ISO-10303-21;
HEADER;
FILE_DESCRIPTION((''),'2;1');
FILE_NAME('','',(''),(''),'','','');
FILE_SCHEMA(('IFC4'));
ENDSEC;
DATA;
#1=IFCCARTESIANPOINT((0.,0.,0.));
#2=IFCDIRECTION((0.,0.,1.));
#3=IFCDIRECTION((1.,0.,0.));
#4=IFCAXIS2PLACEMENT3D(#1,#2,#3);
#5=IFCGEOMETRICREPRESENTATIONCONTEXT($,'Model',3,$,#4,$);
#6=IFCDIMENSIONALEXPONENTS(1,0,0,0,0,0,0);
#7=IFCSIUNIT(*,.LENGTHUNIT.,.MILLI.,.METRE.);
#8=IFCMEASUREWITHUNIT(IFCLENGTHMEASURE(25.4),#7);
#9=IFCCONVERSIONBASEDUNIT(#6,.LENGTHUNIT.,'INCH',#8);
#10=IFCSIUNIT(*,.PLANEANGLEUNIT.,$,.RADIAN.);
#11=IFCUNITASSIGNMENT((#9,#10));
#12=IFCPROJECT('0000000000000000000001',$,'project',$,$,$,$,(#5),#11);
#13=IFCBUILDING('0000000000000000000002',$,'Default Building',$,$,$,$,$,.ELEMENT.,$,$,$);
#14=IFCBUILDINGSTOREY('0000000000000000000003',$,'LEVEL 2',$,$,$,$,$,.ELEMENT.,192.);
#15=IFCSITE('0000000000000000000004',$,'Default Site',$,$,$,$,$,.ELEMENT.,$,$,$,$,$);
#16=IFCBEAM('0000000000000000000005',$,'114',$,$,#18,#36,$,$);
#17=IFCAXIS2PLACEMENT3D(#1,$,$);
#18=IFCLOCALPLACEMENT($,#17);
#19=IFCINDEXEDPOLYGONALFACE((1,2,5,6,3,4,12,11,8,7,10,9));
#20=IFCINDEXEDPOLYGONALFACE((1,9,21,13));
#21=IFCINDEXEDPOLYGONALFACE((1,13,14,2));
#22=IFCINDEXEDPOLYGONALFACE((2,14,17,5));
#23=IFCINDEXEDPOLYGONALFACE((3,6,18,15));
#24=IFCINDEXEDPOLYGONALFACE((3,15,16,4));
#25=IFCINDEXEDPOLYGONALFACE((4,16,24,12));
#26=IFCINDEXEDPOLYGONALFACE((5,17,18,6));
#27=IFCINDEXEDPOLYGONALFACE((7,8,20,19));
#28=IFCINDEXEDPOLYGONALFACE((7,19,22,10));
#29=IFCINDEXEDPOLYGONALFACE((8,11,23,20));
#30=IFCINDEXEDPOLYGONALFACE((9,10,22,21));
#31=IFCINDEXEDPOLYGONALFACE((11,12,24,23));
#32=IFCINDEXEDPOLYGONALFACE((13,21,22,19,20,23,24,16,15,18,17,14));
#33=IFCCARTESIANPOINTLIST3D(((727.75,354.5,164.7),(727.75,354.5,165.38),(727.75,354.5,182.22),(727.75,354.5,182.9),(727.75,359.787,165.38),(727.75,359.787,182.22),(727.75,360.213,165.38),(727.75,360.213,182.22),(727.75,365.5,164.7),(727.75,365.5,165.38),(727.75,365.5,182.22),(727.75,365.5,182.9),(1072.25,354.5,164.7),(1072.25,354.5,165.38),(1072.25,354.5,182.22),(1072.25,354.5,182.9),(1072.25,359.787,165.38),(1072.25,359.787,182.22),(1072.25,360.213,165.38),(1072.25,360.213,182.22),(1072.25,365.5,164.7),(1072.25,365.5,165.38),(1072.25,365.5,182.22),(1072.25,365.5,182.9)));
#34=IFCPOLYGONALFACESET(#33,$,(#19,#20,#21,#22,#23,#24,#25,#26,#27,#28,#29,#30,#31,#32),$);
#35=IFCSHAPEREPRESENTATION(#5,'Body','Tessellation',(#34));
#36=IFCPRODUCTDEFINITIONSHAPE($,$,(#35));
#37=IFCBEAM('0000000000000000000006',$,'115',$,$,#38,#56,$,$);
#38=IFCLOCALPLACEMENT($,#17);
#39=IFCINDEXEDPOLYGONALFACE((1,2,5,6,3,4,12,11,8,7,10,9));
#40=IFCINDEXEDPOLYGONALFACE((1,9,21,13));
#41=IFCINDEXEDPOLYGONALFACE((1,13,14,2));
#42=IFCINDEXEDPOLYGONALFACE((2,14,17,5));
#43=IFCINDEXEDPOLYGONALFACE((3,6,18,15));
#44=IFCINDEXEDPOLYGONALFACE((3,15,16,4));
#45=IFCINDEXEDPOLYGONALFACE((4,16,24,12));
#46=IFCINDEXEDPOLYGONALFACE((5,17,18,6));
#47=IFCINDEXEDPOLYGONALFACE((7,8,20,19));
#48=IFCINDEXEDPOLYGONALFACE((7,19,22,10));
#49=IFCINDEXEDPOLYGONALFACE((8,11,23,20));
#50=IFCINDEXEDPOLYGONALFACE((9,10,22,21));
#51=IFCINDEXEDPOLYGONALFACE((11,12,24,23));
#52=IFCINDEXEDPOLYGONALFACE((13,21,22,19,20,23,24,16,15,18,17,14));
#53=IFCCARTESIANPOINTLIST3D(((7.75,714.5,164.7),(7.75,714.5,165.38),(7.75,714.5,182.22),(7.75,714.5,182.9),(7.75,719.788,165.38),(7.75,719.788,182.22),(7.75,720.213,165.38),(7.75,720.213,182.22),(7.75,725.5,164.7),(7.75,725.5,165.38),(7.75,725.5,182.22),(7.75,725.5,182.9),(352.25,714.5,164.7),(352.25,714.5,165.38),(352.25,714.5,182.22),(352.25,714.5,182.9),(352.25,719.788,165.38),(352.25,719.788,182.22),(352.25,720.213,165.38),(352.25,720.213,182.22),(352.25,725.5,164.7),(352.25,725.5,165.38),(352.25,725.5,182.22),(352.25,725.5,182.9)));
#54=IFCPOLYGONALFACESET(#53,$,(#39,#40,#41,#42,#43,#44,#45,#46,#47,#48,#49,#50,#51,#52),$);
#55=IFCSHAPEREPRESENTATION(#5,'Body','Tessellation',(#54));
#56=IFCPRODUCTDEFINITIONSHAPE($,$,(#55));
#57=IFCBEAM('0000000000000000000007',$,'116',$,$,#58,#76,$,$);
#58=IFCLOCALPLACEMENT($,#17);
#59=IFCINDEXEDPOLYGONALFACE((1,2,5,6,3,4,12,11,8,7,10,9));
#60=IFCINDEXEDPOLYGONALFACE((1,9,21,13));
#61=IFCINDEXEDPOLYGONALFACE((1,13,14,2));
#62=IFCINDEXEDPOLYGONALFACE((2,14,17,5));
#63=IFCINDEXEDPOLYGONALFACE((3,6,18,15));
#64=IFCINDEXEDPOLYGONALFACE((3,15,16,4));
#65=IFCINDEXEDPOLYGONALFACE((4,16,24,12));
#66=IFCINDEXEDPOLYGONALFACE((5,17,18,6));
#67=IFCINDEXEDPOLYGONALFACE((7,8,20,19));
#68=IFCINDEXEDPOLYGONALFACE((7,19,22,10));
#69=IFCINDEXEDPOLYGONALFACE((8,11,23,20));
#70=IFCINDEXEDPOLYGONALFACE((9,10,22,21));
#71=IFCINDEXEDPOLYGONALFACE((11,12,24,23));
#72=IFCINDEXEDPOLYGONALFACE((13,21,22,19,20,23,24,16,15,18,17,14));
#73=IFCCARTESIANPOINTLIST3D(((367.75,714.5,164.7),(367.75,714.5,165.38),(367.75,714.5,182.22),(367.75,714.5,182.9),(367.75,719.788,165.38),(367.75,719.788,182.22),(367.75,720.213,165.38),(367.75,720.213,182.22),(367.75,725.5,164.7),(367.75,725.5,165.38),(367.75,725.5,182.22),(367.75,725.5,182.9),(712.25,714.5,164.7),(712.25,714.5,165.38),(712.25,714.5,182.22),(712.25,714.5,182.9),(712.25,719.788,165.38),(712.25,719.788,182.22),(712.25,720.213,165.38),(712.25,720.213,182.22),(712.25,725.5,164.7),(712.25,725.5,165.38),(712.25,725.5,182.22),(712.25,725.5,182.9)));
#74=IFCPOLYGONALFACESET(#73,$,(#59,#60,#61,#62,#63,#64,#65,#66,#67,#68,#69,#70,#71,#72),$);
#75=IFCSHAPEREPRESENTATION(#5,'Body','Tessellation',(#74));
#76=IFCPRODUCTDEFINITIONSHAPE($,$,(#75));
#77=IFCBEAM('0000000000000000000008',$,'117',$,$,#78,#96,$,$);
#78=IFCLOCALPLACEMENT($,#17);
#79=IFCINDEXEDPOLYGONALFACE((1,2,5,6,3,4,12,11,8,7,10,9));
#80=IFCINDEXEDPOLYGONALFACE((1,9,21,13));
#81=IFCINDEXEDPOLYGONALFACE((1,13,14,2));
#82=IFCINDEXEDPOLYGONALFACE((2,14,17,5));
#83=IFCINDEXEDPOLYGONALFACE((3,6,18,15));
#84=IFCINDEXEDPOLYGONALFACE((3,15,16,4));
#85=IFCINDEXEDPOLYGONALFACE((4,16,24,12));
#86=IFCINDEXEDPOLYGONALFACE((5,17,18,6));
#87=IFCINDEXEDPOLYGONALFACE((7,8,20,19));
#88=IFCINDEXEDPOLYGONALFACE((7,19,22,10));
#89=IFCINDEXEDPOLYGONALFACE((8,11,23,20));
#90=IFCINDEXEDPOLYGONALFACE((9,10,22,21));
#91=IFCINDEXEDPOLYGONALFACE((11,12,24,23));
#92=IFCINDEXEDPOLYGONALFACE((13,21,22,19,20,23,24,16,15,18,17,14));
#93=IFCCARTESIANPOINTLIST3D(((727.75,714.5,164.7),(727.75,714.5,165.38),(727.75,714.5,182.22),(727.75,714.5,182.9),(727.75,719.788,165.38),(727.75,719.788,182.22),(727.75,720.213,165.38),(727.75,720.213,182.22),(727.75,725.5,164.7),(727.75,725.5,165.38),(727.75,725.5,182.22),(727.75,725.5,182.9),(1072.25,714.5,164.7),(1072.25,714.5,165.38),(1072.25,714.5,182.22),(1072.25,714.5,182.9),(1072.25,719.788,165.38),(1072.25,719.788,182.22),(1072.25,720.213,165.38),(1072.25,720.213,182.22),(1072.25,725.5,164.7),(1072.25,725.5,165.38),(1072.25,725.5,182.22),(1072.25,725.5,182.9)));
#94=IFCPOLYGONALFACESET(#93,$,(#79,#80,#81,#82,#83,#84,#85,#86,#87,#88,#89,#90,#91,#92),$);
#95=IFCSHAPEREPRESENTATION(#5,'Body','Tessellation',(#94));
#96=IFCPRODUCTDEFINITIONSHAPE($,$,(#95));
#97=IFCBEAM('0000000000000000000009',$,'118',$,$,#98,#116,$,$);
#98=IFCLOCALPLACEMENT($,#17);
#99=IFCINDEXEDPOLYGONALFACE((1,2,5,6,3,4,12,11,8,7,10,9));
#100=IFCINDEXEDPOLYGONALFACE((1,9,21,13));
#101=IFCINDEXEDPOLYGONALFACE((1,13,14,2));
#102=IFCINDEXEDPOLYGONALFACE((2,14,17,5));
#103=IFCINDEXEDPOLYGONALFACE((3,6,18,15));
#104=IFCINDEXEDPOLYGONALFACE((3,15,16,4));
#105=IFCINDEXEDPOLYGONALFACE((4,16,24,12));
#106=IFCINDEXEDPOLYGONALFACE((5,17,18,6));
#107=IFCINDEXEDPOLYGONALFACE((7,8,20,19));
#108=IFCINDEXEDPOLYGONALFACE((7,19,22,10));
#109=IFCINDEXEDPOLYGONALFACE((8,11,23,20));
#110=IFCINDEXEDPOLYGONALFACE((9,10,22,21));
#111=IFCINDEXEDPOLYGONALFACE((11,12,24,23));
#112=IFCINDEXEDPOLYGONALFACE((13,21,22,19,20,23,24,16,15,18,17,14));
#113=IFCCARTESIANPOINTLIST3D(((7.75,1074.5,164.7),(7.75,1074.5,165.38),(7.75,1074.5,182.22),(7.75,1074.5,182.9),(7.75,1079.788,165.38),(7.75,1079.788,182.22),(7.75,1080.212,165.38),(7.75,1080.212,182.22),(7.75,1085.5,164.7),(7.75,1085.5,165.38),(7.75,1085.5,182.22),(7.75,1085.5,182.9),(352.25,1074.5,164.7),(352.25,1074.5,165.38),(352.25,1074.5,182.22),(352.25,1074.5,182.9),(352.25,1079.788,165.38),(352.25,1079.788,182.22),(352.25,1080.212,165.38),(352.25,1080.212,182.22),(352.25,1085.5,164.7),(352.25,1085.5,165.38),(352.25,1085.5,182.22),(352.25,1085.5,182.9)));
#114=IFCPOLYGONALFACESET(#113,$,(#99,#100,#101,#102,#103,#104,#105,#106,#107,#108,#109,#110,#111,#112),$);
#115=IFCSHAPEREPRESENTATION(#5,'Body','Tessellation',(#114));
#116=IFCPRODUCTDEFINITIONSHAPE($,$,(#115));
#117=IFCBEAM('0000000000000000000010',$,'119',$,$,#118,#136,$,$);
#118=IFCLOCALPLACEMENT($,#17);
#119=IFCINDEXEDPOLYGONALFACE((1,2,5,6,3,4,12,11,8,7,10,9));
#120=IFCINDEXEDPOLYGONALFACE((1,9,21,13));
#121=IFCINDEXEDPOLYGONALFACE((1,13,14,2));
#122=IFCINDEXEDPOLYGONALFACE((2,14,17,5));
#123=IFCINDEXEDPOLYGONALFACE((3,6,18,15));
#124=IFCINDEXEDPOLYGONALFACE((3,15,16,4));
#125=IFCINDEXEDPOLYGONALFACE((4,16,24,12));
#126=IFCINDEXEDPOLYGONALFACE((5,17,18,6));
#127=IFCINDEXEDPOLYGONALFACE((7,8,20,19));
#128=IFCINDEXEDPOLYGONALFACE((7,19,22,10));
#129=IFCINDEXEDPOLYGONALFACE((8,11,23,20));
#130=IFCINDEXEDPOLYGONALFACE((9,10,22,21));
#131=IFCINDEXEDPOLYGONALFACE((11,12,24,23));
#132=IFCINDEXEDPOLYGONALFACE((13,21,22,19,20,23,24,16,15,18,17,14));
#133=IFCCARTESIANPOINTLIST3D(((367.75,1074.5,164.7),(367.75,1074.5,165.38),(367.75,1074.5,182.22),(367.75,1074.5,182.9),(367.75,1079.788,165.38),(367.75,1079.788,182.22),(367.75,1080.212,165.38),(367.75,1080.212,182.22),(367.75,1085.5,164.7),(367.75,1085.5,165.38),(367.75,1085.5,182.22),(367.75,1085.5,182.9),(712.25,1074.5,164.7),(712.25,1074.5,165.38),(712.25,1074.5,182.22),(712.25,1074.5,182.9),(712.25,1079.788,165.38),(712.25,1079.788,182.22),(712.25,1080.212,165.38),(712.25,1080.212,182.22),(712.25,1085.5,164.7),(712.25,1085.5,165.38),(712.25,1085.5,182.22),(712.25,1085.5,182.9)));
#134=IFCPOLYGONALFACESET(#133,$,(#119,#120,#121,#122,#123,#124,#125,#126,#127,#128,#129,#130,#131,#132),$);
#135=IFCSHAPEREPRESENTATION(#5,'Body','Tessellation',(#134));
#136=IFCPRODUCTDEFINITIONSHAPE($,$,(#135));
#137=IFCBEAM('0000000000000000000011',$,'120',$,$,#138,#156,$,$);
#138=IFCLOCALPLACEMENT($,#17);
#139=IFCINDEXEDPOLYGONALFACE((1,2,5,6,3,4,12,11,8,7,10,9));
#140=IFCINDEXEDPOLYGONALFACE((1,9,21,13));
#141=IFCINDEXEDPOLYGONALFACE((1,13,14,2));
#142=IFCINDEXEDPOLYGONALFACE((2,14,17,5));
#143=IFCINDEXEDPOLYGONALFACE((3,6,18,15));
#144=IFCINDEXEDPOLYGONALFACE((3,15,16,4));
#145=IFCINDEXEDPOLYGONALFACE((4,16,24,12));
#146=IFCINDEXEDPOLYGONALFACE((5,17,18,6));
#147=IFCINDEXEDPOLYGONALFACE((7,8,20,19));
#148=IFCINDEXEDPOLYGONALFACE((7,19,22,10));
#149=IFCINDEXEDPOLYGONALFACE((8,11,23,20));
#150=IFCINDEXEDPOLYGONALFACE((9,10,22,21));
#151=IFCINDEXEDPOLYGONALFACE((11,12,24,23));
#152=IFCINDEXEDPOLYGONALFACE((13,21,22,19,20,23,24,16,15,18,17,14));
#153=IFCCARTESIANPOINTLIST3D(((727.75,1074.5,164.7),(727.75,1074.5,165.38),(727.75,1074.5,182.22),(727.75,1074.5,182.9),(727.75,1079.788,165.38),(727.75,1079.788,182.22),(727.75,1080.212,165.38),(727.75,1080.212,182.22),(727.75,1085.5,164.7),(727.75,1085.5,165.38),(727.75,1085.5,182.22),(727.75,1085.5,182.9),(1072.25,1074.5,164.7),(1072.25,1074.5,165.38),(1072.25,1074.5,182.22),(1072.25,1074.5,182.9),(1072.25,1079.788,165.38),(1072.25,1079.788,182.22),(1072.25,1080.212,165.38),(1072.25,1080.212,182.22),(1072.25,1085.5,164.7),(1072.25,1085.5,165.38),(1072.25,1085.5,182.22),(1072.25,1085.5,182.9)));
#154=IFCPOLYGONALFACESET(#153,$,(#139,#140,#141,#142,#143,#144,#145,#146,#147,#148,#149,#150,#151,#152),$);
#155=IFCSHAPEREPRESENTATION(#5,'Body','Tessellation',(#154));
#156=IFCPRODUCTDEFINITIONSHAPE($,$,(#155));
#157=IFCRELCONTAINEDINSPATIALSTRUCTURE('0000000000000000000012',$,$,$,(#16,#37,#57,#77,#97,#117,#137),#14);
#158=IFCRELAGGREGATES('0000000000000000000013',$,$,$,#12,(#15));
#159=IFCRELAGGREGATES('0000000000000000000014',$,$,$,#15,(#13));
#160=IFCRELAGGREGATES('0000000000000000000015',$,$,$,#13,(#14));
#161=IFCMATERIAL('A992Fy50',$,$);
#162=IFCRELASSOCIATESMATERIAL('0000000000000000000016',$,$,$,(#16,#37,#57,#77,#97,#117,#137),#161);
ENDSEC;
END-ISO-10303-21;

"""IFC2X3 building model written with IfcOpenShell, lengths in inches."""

from ifc_helpers import new_model, entity, si_unit, converted_unit, frame, origin_with_axes, origin_2d_with_axis, place, context, project, spatial, i_section, transform_2d, derived_profile, extrude, material, element, save


model = new_model("IFC2X3")

# Units and contexts
model_context = context("Model", 3, world=origin_with_axes())
ifc_project = project(units=[converted_unit("LENGTHUNIT", "INCH", entity("IfcLengthMeasure", 25.4), si_unit("LENGTHUNIT", "METRE", prefix="MILLI"), dimensions=[1, 0, 0, 0, 0, 0, 0]), si_unit("PLANEANGLEUNIT", "RADIAN")], contexts=[model_context])

# Site, building, storey
site = spatial("IfcSite", under=ifc_project, Name="Default Site", CompositionType="ELEMENT")
building = spatial("IfcBuilding", under=site, Name="Default Building", CompositionType="ELEMENT")
storey = spatial("IfcBuildingStorey", under=building, Name="LEVEL 2", CompositionType="ELEMENT", Elevation=192.0)

# Shared definitions
ifc_material = material(Name="A992Fy50")

# Beams
for number, where, z_axis, x_axis, name in (
    (1, (727.75, 360.0, 192.0), (1.0, 0.0, 0.0), (0.0, 1.0, 0.0), "114"),
    (2, (7.75, 720.0, 192.0), (1.0, 0.0, 0.0), (0.0, 1.0, 0.0), "115"),
    (3, (367.75, 720.0, 192.0), (1.0, 0.0, 0.0), (0.0, 1.0, 0.0), "116"),
    (4, (727.75, 720.0, 192.0), (1.0, 0.0, 0.0), (0.0, 1.0, 0.0), "117"),
    (5, (7.75, 1080.0, 192.0), (1.0, 0.0, 0.0), (0.0, 1.0, 0.0), "118"),
    (6, (367.75, 1080.0, 192.0), (1.0, 0.0, 0.0), (0.0, 1.0, 0.0), "119"),
    (7, (727.75, 1080.0, 192.0), (1.0, 0.0, 0.0), (0.0, 1.0, 0.0), "120"),
):
    element("IfcBeam", number, at=place(None, frame(where, z_axis=z_axis, x_axis=x_axis)), inside=storey, material=ifc_material, Name=name, context=model_context, shape_type="SweptSolid", body=[
        extrude(derived_profile(i_section(OverallWidth=11.0, OverallDepth=18.2, WebThickness=0.425, FlangeThickness=0.68, at=origin_2d_with_axis()), transform_2d((0.0, -9.1))), origin_with_axes(), (0.0, 0.0, 1.0), 344.5),
    ])

save(model, "model.ifc")
